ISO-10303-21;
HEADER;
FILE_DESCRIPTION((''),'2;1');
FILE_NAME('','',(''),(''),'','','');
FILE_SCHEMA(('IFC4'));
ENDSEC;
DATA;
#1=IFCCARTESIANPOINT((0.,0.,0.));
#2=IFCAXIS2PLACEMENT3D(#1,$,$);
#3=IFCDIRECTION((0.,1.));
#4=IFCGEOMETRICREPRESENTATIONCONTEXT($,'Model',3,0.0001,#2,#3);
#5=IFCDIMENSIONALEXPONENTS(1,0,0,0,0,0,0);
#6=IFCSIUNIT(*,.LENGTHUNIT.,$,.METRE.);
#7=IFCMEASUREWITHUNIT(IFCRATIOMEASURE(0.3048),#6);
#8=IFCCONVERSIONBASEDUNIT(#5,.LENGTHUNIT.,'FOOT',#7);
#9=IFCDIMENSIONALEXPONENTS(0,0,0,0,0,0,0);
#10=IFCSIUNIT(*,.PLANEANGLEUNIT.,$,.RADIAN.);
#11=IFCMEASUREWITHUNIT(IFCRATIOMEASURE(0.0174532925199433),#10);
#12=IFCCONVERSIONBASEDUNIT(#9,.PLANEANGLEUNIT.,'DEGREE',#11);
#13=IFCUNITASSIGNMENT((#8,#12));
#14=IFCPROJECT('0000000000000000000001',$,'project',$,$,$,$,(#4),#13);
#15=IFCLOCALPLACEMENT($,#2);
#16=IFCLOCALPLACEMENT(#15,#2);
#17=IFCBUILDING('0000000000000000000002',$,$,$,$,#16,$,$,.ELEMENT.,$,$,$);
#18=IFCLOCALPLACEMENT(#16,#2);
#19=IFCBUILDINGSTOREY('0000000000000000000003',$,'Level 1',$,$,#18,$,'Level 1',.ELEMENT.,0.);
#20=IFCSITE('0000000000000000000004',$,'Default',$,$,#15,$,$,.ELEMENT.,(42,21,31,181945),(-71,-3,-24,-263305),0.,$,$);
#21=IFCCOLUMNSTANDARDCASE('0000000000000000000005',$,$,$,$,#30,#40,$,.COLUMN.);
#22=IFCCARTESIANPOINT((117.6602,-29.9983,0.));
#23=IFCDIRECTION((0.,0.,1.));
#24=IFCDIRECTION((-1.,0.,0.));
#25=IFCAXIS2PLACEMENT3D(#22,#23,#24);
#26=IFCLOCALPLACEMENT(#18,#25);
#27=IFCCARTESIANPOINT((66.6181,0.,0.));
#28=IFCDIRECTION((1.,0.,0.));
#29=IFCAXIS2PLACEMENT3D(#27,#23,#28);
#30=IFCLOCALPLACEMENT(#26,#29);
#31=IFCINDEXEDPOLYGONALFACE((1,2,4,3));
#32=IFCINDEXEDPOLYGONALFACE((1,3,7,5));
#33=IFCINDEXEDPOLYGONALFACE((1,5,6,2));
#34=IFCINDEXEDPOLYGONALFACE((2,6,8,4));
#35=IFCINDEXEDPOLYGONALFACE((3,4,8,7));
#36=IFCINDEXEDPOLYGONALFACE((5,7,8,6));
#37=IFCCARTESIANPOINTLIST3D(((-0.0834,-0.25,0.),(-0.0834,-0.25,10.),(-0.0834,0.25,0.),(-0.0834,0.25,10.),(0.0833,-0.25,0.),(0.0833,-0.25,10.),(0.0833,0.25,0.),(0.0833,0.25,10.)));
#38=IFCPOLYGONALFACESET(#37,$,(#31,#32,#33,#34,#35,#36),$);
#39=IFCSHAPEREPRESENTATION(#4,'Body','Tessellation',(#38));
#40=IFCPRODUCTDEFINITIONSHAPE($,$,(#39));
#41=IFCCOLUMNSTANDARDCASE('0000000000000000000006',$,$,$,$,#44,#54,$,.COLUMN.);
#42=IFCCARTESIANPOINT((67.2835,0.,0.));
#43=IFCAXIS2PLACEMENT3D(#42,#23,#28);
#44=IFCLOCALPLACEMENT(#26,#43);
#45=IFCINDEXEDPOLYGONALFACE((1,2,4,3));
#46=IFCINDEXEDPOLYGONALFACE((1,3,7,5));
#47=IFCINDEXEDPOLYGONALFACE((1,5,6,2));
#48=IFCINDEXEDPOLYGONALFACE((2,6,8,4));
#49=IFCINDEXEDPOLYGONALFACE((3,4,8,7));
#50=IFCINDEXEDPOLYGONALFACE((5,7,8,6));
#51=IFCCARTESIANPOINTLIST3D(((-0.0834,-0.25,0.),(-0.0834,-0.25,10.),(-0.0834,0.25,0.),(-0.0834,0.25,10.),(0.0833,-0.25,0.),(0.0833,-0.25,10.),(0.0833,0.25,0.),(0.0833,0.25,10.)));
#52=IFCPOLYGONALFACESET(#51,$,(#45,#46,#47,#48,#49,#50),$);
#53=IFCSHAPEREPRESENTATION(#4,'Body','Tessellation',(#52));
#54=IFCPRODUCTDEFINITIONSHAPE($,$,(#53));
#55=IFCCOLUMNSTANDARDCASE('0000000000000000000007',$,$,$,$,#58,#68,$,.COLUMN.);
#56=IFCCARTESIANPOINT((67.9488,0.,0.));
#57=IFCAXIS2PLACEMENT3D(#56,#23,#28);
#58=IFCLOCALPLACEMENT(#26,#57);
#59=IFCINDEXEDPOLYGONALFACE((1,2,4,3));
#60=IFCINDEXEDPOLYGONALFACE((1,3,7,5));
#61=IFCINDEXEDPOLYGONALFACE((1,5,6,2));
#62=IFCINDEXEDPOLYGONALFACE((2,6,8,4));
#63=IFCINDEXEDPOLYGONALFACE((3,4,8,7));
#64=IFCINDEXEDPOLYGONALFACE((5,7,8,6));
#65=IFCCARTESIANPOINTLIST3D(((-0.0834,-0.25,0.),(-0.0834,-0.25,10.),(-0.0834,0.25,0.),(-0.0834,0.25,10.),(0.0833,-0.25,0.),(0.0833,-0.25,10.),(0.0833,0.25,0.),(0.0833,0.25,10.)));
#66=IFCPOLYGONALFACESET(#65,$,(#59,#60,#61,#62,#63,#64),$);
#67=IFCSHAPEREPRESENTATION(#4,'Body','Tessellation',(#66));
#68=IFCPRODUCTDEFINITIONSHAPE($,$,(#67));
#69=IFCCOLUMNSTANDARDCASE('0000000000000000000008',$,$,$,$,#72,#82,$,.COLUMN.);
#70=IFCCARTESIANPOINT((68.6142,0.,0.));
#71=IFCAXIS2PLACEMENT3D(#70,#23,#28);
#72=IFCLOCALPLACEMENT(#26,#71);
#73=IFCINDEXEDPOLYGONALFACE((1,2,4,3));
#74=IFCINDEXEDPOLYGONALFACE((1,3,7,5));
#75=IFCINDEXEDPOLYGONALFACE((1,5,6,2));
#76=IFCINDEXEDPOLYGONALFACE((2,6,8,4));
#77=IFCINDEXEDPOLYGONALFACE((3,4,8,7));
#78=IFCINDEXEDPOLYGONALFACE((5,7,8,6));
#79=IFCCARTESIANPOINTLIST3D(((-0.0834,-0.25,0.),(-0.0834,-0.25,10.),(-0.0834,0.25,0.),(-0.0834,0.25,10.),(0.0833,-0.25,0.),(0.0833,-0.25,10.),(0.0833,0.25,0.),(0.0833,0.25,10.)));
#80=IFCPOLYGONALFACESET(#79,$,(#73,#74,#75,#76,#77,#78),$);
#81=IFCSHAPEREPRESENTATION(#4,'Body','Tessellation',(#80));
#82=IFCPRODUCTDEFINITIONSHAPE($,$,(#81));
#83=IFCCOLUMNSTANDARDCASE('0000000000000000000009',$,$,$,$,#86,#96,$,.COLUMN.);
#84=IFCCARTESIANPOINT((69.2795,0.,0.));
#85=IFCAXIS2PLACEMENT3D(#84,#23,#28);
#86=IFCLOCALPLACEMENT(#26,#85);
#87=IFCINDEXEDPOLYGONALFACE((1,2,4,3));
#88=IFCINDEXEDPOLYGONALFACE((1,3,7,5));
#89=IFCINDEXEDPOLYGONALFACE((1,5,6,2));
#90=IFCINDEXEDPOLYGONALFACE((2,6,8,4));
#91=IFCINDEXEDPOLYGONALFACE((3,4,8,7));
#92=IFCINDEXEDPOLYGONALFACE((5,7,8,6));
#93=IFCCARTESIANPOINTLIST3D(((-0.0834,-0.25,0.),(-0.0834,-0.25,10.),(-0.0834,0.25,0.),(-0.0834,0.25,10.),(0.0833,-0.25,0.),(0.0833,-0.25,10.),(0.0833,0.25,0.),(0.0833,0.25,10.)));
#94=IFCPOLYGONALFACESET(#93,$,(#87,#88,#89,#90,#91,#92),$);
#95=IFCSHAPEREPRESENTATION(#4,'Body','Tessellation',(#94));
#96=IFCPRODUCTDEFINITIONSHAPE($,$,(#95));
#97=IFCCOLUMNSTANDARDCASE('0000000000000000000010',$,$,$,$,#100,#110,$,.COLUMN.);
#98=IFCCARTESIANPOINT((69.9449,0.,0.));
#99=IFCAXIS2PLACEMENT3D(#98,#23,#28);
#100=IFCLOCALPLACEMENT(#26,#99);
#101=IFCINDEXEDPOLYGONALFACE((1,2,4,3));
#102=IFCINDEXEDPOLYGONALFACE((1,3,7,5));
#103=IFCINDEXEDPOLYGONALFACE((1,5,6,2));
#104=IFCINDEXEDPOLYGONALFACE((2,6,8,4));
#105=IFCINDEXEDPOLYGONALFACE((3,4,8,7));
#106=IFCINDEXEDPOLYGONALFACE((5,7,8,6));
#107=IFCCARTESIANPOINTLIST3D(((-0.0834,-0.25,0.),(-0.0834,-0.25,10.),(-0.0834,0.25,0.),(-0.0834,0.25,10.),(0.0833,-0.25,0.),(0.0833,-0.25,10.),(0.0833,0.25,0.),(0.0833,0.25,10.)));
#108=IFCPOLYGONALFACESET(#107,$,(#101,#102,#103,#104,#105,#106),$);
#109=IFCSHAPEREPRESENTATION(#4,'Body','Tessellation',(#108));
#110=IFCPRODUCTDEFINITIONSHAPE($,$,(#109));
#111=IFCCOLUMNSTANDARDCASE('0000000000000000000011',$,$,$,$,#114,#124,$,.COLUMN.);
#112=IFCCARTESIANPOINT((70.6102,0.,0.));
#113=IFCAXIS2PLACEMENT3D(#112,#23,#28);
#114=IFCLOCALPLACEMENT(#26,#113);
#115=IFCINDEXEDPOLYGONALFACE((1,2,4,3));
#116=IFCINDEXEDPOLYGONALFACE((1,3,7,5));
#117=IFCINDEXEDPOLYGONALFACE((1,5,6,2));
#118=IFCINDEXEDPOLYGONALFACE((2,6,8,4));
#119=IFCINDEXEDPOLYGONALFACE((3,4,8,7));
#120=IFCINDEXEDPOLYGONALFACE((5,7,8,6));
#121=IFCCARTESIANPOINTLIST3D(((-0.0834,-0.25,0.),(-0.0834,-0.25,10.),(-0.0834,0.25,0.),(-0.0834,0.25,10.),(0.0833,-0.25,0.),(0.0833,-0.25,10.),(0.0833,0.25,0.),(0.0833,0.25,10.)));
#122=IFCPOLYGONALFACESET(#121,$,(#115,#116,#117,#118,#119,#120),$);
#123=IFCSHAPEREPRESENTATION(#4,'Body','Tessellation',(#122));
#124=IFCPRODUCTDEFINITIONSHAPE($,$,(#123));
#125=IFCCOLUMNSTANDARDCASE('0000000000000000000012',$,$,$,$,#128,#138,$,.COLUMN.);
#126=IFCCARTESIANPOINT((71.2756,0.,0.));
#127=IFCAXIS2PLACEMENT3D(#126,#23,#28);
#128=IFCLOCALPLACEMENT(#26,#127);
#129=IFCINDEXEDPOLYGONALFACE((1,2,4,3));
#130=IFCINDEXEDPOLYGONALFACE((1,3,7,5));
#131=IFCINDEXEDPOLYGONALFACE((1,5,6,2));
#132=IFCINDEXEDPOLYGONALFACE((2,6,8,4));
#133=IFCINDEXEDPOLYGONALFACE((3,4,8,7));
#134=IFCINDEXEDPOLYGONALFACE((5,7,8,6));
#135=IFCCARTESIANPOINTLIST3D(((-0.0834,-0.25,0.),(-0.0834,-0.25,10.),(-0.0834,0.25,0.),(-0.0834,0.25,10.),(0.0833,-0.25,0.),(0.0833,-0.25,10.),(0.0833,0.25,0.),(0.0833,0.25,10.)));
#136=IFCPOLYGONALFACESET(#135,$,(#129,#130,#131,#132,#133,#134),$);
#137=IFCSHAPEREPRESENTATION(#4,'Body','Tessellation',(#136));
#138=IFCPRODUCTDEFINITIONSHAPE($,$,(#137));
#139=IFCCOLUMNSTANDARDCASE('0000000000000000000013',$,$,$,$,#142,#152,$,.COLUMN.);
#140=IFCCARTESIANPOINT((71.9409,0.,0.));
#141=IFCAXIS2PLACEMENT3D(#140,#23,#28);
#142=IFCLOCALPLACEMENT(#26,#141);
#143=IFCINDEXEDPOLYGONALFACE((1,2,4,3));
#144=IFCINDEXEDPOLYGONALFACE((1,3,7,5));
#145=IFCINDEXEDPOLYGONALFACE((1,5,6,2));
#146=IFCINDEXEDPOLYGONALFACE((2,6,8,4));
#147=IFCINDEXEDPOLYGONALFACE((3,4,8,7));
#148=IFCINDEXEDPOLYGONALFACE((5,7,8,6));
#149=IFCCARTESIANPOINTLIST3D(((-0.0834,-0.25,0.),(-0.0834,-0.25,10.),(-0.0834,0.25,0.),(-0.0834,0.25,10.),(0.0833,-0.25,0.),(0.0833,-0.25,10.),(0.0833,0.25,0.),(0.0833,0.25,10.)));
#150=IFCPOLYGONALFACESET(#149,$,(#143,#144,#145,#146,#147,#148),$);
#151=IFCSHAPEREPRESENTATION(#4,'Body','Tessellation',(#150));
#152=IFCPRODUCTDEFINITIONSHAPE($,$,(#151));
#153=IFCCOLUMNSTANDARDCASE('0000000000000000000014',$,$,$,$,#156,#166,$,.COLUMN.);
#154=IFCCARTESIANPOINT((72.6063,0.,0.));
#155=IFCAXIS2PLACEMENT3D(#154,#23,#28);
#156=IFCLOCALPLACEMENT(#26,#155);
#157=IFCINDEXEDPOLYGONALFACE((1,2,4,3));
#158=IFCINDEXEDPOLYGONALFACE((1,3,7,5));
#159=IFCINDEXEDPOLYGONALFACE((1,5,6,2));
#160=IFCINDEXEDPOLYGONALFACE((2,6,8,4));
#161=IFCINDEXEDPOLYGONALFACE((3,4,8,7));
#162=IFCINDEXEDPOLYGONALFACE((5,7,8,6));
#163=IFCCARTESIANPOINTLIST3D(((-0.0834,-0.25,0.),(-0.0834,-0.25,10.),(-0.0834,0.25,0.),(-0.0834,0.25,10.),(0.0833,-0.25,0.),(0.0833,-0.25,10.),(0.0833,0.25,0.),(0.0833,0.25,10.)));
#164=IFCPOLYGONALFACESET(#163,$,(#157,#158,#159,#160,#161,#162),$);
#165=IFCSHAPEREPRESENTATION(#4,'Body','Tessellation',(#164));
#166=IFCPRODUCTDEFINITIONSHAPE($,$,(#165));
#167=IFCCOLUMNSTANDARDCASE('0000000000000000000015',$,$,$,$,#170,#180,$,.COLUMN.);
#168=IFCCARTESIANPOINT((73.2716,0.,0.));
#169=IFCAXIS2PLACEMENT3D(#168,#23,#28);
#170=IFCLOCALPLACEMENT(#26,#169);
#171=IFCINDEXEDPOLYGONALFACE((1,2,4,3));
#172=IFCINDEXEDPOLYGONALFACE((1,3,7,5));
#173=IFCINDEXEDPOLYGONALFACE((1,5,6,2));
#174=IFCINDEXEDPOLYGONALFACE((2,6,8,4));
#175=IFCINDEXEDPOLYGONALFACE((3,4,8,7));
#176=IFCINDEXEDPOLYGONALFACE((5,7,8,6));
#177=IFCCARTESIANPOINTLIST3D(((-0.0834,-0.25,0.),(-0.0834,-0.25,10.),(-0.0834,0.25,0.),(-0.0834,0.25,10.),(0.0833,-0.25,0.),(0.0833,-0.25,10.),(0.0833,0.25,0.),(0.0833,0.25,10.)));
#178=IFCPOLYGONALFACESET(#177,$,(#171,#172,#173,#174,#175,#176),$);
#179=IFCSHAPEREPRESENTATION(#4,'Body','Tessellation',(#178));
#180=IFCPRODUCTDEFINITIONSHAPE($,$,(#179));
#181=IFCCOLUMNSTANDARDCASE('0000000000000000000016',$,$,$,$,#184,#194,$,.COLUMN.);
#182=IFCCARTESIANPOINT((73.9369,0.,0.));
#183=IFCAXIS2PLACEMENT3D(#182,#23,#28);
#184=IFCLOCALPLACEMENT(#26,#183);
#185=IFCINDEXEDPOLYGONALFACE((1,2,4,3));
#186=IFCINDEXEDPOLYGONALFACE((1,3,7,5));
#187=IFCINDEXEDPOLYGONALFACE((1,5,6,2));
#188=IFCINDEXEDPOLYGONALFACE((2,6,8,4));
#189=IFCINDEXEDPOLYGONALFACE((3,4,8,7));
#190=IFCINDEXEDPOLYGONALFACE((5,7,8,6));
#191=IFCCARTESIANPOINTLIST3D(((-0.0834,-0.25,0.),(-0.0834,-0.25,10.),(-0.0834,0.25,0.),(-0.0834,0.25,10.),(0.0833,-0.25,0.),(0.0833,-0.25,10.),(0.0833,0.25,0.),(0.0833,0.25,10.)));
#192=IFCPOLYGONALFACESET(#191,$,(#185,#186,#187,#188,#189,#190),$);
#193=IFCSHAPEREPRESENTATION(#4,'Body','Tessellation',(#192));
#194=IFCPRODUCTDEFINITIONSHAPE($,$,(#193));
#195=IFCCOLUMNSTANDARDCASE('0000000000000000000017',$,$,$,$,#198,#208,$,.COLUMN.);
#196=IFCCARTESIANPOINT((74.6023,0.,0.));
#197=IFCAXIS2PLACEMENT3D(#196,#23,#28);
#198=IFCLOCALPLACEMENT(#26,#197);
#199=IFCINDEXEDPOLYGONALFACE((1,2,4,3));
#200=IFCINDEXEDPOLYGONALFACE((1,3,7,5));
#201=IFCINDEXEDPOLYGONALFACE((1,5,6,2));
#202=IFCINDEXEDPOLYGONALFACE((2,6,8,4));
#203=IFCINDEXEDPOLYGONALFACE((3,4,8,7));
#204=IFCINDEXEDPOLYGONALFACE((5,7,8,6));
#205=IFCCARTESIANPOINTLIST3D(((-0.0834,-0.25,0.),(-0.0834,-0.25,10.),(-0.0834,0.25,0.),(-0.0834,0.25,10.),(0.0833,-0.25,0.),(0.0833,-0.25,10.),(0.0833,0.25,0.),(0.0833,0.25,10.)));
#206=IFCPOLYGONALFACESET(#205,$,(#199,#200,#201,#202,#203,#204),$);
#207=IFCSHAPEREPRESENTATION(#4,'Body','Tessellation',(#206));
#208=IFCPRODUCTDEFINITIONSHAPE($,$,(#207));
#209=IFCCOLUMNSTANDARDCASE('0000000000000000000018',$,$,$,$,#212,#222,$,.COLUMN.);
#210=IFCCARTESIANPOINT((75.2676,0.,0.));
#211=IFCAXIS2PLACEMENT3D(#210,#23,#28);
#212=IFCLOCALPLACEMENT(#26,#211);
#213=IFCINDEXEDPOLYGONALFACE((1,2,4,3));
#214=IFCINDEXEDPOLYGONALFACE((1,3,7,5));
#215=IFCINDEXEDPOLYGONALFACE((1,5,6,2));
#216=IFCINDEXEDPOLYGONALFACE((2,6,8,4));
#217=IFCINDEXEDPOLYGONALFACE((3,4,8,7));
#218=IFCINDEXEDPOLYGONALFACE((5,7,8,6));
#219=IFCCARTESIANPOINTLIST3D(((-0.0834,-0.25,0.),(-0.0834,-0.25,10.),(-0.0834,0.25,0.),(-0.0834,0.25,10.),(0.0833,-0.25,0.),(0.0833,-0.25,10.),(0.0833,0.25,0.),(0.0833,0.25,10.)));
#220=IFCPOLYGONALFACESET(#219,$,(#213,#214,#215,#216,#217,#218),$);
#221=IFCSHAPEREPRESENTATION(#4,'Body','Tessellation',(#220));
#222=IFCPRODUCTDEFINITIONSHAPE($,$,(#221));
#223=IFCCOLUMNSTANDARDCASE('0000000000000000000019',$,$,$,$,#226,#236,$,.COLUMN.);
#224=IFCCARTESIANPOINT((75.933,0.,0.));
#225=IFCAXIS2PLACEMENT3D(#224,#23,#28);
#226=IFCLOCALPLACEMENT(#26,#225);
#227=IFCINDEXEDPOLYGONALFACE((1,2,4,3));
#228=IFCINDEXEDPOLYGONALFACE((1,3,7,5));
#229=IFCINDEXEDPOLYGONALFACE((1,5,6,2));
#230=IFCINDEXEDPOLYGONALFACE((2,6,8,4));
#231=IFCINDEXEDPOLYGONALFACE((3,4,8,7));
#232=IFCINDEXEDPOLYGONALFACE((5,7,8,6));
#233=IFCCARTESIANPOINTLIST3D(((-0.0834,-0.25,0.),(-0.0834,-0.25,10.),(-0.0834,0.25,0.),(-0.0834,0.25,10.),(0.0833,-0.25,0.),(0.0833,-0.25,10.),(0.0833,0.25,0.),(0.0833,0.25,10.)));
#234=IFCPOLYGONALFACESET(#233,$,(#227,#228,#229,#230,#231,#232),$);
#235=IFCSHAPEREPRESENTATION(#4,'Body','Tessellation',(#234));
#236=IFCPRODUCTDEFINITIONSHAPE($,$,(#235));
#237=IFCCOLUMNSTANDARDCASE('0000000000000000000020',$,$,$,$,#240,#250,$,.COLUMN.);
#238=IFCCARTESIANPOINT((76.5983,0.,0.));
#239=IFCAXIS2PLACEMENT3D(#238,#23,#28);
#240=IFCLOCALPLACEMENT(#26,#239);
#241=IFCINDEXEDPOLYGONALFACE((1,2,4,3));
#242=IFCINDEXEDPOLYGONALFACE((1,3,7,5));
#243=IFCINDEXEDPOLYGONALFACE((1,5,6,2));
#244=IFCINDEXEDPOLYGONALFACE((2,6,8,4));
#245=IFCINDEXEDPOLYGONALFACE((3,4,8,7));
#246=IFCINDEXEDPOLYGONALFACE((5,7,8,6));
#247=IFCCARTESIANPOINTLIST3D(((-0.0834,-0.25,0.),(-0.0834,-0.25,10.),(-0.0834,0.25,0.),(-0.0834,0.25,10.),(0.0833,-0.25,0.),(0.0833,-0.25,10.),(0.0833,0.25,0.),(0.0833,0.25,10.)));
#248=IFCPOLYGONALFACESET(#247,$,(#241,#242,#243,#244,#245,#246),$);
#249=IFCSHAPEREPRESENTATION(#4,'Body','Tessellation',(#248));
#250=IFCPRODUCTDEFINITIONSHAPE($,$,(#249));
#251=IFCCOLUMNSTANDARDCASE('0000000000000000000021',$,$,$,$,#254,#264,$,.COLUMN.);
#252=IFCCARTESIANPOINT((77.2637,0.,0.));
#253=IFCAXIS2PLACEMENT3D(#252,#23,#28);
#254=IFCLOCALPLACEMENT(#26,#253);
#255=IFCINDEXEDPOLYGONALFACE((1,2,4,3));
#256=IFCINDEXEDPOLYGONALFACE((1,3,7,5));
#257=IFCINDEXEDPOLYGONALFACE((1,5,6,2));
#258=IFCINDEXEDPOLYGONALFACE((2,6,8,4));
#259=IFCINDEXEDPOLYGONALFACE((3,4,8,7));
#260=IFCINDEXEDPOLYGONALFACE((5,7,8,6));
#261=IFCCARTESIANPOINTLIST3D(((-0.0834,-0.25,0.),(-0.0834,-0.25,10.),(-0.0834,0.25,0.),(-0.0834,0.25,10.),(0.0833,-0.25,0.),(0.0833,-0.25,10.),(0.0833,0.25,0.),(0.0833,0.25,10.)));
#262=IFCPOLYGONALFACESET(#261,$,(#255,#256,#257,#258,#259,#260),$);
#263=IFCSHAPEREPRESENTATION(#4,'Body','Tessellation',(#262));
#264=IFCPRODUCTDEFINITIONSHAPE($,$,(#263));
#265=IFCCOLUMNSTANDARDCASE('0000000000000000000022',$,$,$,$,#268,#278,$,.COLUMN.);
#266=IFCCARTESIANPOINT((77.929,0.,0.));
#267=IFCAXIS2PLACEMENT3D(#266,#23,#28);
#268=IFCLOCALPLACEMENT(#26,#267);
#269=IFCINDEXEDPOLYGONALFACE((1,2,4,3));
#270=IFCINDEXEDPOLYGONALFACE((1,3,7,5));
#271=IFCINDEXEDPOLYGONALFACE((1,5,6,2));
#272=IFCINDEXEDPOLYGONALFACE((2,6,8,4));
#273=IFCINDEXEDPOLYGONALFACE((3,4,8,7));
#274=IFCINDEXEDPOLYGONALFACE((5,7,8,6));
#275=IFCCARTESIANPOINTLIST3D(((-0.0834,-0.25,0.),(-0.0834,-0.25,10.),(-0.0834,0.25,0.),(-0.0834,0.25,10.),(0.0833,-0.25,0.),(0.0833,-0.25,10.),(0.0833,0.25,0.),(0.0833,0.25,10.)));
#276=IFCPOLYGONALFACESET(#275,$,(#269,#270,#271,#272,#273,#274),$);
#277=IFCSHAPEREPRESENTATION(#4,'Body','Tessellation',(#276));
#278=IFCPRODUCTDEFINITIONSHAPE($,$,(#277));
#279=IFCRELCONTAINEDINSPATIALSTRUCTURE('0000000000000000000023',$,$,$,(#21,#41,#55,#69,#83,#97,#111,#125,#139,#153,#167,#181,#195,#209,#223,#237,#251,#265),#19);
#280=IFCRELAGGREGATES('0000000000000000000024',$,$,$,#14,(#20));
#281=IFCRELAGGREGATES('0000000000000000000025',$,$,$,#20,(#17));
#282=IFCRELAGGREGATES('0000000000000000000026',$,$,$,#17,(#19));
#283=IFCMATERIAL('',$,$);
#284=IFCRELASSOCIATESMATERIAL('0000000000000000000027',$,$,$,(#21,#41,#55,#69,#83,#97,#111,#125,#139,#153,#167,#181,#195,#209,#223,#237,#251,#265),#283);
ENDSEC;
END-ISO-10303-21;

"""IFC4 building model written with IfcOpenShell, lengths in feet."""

from ifc_helpers import new_model, entity, si_unit, converted_unit, direction, frame, origin, place, context, project, spatial, rectangle, extrude, material, element, save


model = new_model("IFC4")

# Units and contexts
model_context = context("Model", 3, precision=0.0001, world=origin(), true_north=direction((0.0, 1.0)))
ifc_project = project(units=[converted_unit("LENGTHUNIT", "FOOT", entity("IfcRatioMeasure", 0.3048), si_unit("LENGTHUNIT", "METRE"), dimensions=[1, 0, 0, 0, 0, 0, 0]), converted_unit("PLANEANGLEUNIT", "DEGREE", entity("IfcRatioMeasure", 0.0174532925199433), si_unit("PLANEANGLEUNIT", "RADIAN"), dimensions=[0, 0, 0, 0, 0, 0, 0])], contexts=[model_context])

# Site, building, storey
site_placement = place(None, origin())
site = spatial("IfcSite", under=ifc_project, at=site_placement, Name="Default", CompositionType="ELEMENT", RefLatitude=(42, 21, 31, 181945), RefLongitude=(-71, -3, -24, -263305), RefElevation=0.0)
building_placement = place(site_placement, origin())
building = spatial("IfcBuilding", under=site, at=building_placement, CompositionType="ELEMENT")
storey_placement = place(building_placement, origin())
storey = spatial("IfcBuildingStorey", under=building, at=storey_placement, Name="Level 1", LongName="Level 1", CompositionType="ELEMENT", Elevation=0.0)

# Columns
ifc_material_1 = material(Name="")
placement = place(storey_placement, frame((117.6602, -29.9983, 0.0), z_axis=(0.0, 0.0, 1.0), x_axis=(-1.0, 0.0, 0.0)))
for number, where, z_axis, x_axis in (
    (1, (66.6181, 0.0, 0.0), (0.0, 0.0, 1.0), (1.0, 0.0, 0.0)),
    (2, (67.2835, 0.0, 0.0), (0.0, 0.0, 1.0), (1.0, 0.0, 0.0)),
    (3, (67.9488, 0.0, 0.0), (0.0, 0.0, 1.0), (1.0, 0.0, 0.0)),
    (4, (68.6142, 0.0, 0.0), (0.0, 0.0, 1.0), (1.0, 0.0, 0.0)),
    (5, (69.2795, 0.0, 0.0), (0.0, 0.0, 1.0), (1.0, 0.0, 0.0)),
    (6, (69.9449, 0.0, 0.0), (0.0, 0.0, 1.0), (1.0, 0.0, 0.0)),
    (7, (70.6102, 0.0, 0.0), (0.0, 0.0, 1.0), (1.0, 0.0, 0.0)),
    (8, (71.2756, 0.0, 0.0), (0.0, 0.0, 1.0), (1.0, 0.0, 0.0)),
    (9, (71.9409, 0.0, 0.0), (0.0, 0.0, 1.0), (1.0, 0.0, 0.0)),
    (10, (72.6063, 0.0, 0.0), (0.0, 0.0, 1.0), (1.0, 0.0, 0.0)),
    (11, (73.2716, 0.0, 0.0), (0.0, 0.0, 1.0), (1.0, 0.0, 0.0)),
    (12, (73.9369, 0.0, 0.0), (0.0, 0.0, 1.0), (1.0, 0.0, 0.0)),
    (13, (74.6023, 0.0, 0.0), (0.0, 0.0, 1.0), (1.0, 0.0, 0.0)),
    (14, (75.2676, 0.0, 0.0), (0.0, 0.0, 1.0), (1.0, 0.0, 0.0)),
    (15, (75.933, 0.0, 0.0), (0.0, 0.0, 1.0), (1.0, 0.0, 0.0)),
    (16, (76.5983, 0.0, 0.0), (0.0, 0.0, 1.0), (1.0, 0.0, 0.0)),
    (17, (77.2637, 0.0, 0.0), (0.0, 0.0, 1.0), (1.0, 0.0, 0.0)),
    (18, (77.929, 0.0, 0.0), (0.0, 0.0, 1.0), (1.0, 0.0, 0.0)),
):
    element("IfcColumnStandardCase", number, at=place(placement, frame(where, z_axis=z_axis, x_axis=x_axis)), inside=storey, material=ifc_material_1, PredefinedType="COLUMN", context=model_context, shape_type="SweptSolid", body=[
        extrude(rectangle(XDim=0.1667, YDim=0.5), origin(), (0.0, 0.0, 1.0), 10.0),
    ])

save(model, "model.ifc")
